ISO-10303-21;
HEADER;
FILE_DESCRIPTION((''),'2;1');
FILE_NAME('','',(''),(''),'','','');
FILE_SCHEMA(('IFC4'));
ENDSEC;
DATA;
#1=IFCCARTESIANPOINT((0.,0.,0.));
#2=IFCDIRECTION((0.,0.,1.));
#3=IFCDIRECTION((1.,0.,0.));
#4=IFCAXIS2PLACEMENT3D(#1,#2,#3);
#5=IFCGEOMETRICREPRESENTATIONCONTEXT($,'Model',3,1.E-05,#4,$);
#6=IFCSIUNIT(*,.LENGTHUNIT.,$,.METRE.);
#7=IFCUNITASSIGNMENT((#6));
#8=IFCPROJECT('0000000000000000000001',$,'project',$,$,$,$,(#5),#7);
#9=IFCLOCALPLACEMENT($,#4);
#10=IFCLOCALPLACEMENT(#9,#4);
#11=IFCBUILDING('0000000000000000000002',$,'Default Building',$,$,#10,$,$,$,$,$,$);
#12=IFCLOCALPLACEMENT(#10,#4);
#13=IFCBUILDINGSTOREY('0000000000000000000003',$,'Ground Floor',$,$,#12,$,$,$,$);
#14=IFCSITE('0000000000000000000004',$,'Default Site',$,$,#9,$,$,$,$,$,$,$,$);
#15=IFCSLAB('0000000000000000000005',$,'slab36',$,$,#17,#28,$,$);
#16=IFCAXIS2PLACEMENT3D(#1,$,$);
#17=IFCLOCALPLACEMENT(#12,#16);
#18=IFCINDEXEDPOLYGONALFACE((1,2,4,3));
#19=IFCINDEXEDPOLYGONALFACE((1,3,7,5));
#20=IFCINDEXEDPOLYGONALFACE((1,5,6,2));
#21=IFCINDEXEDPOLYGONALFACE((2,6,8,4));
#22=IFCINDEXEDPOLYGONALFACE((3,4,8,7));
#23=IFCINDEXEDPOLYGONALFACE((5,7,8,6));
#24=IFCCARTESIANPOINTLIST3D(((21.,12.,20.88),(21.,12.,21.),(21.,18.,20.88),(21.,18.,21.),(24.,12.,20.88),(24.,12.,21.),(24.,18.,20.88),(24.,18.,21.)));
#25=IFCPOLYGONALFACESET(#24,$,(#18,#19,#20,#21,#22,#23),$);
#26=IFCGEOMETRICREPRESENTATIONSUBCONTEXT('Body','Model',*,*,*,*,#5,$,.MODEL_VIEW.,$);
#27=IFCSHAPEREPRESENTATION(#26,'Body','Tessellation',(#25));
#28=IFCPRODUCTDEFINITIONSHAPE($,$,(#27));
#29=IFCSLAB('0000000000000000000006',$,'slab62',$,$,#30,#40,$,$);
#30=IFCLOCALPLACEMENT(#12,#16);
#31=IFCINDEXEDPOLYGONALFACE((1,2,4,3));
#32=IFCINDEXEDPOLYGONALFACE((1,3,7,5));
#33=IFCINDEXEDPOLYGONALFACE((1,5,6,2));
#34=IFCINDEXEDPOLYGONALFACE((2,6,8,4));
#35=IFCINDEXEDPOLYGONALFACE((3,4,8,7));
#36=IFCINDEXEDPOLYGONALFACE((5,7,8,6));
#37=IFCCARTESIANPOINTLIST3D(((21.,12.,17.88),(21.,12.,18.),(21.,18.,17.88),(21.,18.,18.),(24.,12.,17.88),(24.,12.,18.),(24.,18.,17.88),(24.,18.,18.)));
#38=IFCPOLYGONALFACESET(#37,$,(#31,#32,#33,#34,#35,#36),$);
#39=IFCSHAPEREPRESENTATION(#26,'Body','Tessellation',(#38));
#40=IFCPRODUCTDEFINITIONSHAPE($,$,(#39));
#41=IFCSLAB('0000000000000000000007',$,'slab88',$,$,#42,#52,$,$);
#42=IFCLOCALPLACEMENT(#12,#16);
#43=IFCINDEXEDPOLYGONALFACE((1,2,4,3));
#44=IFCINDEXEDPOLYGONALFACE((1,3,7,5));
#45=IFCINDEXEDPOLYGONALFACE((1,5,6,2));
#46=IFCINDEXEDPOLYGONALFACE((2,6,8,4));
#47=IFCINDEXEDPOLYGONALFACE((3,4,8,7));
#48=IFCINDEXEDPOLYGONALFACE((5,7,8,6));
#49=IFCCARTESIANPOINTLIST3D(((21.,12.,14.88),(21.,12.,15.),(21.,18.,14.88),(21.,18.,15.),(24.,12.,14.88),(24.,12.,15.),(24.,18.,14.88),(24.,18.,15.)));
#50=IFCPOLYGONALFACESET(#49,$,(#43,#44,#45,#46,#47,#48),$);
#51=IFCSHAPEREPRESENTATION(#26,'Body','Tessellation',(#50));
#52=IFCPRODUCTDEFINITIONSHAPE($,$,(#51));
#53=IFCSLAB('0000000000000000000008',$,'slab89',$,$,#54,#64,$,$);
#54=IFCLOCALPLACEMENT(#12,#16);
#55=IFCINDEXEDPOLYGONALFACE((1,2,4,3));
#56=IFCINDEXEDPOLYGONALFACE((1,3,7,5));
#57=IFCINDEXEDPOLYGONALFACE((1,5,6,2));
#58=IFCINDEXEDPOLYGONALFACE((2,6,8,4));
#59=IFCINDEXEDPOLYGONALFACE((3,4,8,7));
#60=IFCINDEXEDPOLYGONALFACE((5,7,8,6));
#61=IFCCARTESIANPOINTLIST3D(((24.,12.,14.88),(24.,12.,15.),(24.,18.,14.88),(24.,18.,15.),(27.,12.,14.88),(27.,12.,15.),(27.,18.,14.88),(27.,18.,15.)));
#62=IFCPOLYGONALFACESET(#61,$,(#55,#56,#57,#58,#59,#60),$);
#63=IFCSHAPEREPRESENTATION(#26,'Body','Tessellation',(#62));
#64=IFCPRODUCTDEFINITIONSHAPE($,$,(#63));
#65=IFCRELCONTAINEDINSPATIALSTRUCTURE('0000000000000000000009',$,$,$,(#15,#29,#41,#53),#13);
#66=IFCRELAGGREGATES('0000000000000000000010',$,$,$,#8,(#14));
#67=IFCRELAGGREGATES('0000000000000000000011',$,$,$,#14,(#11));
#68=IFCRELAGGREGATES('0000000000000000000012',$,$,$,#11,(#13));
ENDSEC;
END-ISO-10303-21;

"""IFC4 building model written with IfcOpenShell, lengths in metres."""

from ifc_helpers import new_model, si_unit, frame, origin_with_axes, place, context, subcontext, project, spatial, indexed_curve, outline, extrude, element, save


model = new_model("IFC4")

# Units and contexts
model_context = context("Model", 3, precision=1e-05, world=origin_with_axes())
body_context = subcontext(model_context, "Body", "Model", "MODEL_VIEW")
ifc_project = project(units=[si_unit("LENGTHUNIT", "METRE")], contexts=[model_context])

# Site, building, storey
site_placement = place(None, origin_with_axes())
site = spatial("IfcSite", under=ifc_project, at=site_placement, Name="Default Site")
building_placement = place(site_placement, origin_with_axes())
building = spatial("IfcBuilding", under=site, at=building_placement, Name="Default Building")
storey_placement = place(building_placement, origin_with_axes())
storey = spatial("IfcBuildingStorey", under=building, at=storey_placement, Name="Ground Floor")

# Slabs
for number, where, z_axis, x_axis, name in (
    (1, (21.0, 12.0, 20.88), (0.0, 0.0, 1.0), (1.0, 0.0, 0.0), "slab36"),
    (2, (21.0, 12.0, 17.88), (0.0, 0.0, 1.0), (1.0, 0.0, 0.0), "slab62"),
    (3, (21.0, 12.0, 14.88), (0.0, 0.0, 1.0), (1.0, 0.0, 0.0), "slab88"),
    (4, (24.0, 12.0, 14.88), (0.0, 0.0, 1.0), (1.0, 0.0, 0.0), "slab89"),
):
    element("IfcSlab", number, at=place(storey_placement, frame(where, z_axis=z_axis, x_axis=x_axis)), inside=storey, Name=name, context=body_context, shape_type="SweptSolid", body=[
        extrude(outline(indexed_curve([(0.0, 0.0), (0.0, 6.0), (3.0, 6.0), (3.0, 0.0), (0.0, 0.0)], self_intersect=False)), origin_with_axes(), (0.0, 0.0, 1.0), 0.12),
    ])

save(model, "model.ifc")
